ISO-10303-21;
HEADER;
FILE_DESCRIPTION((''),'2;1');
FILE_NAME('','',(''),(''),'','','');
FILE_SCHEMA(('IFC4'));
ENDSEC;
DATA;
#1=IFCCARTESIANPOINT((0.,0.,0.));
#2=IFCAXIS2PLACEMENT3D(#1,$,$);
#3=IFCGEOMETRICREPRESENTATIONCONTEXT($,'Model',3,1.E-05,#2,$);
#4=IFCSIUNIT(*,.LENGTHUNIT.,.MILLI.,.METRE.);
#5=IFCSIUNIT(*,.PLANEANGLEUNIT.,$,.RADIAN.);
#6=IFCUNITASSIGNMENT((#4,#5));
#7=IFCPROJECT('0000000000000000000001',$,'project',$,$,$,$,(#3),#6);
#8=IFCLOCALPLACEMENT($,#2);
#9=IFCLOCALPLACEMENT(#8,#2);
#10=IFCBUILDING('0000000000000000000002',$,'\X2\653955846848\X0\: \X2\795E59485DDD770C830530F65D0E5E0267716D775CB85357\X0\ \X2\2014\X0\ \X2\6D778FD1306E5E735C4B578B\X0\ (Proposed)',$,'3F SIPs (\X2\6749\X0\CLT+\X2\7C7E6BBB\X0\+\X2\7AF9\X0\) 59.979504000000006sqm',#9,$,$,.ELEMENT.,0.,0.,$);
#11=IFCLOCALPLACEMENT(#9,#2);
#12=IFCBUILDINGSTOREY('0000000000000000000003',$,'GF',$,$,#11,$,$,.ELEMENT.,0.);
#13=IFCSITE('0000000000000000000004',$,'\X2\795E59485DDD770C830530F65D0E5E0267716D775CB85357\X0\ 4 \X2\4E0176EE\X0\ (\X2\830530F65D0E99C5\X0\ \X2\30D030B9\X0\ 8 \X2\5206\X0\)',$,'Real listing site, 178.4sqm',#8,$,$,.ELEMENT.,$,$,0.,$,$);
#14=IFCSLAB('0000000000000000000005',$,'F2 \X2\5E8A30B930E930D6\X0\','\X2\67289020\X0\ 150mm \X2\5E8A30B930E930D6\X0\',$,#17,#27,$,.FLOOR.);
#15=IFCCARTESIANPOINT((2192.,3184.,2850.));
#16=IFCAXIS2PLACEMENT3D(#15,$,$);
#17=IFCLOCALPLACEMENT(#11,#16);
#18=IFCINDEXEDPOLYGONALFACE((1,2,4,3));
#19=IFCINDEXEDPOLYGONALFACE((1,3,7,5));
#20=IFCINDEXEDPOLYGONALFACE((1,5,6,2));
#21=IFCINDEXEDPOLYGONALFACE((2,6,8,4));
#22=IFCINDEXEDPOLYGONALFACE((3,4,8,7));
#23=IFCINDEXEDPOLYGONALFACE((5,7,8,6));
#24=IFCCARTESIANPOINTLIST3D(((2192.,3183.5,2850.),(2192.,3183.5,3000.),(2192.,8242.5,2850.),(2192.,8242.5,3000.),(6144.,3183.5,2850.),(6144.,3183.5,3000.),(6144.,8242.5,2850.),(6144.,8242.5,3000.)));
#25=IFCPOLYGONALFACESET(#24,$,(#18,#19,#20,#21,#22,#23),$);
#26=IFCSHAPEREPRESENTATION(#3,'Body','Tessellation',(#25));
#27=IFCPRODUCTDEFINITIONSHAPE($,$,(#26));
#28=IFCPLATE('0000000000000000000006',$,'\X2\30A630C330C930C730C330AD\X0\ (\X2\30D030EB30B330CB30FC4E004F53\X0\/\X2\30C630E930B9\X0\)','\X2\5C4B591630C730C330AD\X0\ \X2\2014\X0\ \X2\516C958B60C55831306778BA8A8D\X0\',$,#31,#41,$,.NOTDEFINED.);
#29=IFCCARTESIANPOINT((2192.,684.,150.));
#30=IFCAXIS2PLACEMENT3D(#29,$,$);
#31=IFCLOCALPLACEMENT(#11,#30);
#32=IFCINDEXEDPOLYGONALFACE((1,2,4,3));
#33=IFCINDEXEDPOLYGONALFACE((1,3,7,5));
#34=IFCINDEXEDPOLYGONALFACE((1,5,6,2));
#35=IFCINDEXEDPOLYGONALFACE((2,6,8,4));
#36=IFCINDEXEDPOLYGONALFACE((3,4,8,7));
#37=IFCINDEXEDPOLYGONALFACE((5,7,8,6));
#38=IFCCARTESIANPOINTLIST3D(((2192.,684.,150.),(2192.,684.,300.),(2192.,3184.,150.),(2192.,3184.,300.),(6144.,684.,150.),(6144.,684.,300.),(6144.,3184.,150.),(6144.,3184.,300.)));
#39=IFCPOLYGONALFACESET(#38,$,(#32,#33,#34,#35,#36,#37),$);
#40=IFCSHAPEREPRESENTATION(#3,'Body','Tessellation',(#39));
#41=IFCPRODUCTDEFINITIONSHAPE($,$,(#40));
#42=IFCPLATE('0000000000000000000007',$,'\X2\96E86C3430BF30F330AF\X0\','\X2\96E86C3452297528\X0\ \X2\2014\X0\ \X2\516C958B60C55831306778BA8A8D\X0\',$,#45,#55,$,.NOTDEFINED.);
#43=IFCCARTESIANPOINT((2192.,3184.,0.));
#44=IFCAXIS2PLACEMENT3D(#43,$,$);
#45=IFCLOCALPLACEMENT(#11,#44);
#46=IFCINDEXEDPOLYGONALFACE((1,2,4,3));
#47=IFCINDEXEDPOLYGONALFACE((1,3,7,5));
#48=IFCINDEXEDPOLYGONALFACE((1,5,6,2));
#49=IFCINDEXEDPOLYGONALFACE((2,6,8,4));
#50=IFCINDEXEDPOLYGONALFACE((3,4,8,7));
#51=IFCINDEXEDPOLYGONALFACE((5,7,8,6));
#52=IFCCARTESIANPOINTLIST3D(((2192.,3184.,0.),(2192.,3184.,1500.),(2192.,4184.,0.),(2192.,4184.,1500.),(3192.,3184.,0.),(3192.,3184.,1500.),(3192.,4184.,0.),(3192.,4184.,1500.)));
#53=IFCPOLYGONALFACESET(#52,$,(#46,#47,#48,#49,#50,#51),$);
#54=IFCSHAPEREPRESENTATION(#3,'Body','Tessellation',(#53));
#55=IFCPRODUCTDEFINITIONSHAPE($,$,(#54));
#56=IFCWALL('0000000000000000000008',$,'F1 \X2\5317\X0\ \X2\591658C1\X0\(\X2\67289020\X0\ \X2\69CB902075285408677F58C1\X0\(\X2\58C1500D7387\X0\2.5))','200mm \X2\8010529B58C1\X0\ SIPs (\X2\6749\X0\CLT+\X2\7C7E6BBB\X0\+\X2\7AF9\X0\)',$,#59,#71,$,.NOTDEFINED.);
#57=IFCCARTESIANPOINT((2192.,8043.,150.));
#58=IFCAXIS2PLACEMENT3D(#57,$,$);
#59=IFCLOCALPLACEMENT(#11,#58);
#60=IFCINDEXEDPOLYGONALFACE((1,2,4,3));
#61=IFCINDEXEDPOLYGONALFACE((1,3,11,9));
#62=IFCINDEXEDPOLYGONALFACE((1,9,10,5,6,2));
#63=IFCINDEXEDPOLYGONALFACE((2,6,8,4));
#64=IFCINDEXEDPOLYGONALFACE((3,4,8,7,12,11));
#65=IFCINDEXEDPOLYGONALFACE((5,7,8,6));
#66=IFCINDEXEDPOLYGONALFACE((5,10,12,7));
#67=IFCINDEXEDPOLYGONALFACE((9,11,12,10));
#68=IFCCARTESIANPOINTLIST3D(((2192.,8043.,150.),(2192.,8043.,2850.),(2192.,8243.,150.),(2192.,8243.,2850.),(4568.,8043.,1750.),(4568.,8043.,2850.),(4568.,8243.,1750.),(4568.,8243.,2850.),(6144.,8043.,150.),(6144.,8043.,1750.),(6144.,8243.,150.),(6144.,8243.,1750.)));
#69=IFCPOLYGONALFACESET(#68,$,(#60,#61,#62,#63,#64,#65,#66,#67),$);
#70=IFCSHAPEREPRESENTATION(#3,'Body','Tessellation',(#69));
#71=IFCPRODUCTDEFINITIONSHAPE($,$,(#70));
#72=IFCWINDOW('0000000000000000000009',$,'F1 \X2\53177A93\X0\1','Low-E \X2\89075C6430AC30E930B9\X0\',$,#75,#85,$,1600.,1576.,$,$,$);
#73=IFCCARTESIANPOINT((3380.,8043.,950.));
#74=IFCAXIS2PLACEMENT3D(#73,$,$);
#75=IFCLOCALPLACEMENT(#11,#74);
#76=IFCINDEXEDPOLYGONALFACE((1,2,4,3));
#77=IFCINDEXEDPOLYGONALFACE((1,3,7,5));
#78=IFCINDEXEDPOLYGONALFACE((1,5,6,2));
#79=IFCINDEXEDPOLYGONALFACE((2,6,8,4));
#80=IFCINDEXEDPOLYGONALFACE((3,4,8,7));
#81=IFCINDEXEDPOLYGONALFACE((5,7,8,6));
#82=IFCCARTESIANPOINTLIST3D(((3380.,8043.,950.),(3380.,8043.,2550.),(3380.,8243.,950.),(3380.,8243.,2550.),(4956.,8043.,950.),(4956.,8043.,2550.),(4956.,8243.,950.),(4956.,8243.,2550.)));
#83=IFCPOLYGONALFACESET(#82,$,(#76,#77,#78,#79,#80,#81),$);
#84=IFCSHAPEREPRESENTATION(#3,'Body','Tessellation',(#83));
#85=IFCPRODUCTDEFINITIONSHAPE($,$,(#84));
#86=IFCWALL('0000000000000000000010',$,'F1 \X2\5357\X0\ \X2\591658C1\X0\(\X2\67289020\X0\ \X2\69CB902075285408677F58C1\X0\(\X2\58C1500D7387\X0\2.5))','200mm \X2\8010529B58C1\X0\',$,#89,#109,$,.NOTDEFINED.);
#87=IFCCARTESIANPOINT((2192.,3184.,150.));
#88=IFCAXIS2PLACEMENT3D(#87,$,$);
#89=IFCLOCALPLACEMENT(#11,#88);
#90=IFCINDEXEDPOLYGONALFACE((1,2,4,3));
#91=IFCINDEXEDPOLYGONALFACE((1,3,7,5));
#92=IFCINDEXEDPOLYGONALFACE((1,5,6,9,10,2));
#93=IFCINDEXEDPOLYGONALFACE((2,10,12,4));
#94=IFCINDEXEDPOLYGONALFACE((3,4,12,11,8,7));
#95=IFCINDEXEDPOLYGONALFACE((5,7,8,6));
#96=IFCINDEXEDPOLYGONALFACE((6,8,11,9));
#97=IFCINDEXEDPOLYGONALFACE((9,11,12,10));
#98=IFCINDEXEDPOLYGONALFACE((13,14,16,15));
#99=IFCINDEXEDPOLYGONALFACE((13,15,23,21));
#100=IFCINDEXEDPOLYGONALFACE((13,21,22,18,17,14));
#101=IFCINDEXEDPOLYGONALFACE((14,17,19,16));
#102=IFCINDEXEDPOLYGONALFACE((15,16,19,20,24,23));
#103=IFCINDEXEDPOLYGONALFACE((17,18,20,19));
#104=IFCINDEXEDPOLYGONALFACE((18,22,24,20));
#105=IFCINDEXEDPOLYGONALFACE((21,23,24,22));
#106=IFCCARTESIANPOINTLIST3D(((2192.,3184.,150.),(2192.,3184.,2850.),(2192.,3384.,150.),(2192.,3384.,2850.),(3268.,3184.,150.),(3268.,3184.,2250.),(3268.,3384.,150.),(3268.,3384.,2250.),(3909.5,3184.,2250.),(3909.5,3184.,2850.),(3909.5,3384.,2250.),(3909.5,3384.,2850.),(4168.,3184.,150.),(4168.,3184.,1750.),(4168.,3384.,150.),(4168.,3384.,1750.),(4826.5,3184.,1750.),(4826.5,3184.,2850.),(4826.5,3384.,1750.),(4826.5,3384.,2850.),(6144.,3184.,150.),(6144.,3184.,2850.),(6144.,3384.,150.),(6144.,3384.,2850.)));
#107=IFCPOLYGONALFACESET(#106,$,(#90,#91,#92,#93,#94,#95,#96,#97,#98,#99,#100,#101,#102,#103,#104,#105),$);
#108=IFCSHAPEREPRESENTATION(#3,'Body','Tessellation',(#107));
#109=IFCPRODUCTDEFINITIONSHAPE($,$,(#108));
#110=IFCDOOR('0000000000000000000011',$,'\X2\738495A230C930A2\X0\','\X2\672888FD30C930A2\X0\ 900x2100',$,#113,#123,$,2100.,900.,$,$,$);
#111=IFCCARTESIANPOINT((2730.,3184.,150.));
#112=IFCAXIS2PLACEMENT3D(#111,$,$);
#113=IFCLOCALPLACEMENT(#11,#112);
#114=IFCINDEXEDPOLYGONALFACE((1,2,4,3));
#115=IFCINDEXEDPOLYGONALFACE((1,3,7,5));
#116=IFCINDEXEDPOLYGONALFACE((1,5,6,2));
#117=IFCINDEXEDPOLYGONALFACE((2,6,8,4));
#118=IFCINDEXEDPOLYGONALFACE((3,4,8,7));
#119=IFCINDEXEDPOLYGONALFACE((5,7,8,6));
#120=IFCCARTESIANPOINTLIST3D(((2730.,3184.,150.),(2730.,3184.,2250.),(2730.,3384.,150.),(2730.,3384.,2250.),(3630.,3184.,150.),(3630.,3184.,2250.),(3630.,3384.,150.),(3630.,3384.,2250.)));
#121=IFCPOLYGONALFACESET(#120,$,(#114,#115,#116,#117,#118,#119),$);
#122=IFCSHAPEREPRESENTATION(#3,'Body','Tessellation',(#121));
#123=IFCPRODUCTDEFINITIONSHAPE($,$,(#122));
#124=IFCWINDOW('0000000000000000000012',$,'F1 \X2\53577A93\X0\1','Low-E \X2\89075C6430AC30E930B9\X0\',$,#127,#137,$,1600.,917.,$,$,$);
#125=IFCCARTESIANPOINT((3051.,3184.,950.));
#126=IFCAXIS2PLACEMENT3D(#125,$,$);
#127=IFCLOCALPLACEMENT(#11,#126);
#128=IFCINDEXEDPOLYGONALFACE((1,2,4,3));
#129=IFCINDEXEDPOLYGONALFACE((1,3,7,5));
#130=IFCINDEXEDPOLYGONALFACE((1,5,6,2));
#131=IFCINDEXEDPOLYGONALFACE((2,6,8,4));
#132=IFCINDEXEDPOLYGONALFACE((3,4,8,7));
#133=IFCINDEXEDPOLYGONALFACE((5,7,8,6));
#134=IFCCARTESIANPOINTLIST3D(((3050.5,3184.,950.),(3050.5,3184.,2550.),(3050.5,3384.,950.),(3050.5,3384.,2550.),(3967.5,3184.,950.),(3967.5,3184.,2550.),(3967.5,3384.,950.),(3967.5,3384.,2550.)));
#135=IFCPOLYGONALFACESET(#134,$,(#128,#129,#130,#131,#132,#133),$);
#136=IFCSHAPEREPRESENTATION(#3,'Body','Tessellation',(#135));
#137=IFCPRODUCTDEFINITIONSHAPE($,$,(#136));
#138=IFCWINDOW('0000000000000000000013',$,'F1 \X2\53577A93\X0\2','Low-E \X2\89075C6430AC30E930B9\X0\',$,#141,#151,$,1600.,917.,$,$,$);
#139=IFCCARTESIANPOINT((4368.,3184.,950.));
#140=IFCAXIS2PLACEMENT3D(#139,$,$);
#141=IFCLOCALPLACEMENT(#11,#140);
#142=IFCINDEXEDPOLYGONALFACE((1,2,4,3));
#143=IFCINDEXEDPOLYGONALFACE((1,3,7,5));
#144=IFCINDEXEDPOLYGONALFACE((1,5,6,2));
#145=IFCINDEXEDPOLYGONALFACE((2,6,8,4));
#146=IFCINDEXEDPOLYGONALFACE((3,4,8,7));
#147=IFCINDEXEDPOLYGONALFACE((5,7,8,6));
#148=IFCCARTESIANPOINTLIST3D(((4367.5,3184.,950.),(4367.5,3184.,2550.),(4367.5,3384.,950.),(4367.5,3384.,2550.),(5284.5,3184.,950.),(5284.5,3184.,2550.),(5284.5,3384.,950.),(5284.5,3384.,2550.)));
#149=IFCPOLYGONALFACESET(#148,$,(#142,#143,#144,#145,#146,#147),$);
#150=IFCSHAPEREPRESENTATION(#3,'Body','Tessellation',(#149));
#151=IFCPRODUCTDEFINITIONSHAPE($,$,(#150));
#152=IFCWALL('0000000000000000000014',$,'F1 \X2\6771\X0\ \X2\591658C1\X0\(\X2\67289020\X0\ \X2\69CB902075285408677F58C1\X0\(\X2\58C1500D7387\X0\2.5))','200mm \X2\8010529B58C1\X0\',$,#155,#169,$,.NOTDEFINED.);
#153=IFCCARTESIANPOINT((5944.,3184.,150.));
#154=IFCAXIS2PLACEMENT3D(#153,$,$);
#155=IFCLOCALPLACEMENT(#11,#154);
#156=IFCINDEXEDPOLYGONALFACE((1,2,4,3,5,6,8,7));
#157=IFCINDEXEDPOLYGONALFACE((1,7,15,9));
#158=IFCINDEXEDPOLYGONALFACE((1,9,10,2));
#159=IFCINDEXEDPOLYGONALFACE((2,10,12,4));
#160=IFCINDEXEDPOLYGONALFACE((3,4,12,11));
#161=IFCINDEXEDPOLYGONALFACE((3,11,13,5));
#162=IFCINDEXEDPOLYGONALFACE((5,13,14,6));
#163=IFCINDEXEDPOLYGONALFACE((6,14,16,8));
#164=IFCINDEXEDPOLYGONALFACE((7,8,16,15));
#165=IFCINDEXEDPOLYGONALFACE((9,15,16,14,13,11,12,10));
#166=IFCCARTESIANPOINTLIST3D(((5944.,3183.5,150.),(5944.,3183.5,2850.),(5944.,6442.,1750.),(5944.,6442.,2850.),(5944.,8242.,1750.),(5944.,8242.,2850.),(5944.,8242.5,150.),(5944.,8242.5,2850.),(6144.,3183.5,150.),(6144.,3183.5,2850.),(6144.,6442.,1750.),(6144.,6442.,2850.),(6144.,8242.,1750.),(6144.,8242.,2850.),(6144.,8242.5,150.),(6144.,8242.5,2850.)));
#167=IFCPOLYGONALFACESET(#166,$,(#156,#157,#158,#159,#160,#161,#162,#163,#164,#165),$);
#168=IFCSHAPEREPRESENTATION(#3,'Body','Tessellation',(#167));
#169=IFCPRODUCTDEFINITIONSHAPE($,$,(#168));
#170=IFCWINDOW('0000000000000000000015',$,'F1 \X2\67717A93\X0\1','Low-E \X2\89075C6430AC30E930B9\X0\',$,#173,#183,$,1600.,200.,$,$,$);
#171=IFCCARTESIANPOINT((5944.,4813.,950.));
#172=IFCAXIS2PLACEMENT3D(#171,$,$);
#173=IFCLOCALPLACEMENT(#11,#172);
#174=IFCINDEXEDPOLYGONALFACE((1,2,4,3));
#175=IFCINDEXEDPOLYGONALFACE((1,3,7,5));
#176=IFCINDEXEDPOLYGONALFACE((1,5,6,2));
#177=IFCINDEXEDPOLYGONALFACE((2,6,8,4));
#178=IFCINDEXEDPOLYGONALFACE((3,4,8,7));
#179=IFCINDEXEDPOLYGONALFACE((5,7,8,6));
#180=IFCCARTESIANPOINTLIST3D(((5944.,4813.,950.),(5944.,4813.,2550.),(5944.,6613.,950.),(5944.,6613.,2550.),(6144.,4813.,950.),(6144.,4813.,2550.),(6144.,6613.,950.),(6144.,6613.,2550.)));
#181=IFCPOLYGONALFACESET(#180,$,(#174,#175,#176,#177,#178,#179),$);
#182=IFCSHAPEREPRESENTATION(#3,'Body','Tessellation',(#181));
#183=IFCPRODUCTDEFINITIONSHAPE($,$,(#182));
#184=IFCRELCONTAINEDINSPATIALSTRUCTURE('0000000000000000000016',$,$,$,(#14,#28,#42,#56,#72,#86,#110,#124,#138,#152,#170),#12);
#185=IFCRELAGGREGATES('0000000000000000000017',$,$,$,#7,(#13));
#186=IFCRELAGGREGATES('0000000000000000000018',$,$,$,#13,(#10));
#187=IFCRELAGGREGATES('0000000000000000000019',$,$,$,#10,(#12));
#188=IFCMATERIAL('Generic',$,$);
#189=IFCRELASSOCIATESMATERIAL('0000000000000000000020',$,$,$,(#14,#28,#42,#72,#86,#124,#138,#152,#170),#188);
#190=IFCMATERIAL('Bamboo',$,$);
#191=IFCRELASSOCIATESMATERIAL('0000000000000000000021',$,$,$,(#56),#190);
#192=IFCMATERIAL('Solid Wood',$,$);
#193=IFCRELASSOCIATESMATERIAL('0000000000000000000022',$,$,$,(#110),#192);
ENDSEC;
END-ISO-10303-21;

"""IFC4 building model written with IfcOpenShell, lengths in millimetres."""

from ifc_helpers import new_model, si_unit, frame, frame_2d, origin, place, context, project, spatial, rectangle, extrude, material, element, fill, save


model = new_model("IFC4")

# Units and contexts
model_context = context("Model", 3, precision=1e-05, world=origin())
ifc_project = project(units=[si_unit("LENGTHUNIT", "METRE", prefix="MILLI"), si_unit("PLANEANGLEUNIT", "RADIAN")], contexts=[model_context])

# Site, building, storey
site_placement = place(None, origin())
site = spatial("IfcSite", under=ifc_project, at=site_placement, Name="神奈川県茅ヶ崎市東海岸南 4 丁目 (茅ヶ崎駅 バス 8 分)", ObjectType="Real listing site, 178.4sqm", CompositionType="ELEMENT", RefElevation=0.0)
building_placement = place(site_placement, origin())
building = spatial("IfcBuilding", under=site, at=building_placement, Name="改善案: 神奈川県茅ヶ崎市東海岸南 — 海近の平屋型 (Proposed)", ObjectType="3F SIPs (杉CLT+籾殻+竹) 59.979504000000006sqm", CompositionType="ELEMENT", ElevationOfRefHeight=0.0, ElevationOfTerrain=0.0)
storey_placement = place(building_placement, origin())
storey = spatial("IfcBuildingStorey", under=building, at=storey_placement, Name="GF", CompositionType="ELEMENT", Elevation=0.0)

# Slab
ifc_material_1 = material(Name="Generic")
slab_1_placement = place(storey_placement, frame((2192.0, 3184.0, 2850.0)))
element("IfcSlab", 1, at=slab_1_placement, inside=storey, material=ifc_material_1, Name="F2 床スラブ", Description="木造 150mm 床スラブ", PredefinedType="FLOOR", context=model_context, shape_type="SweptSolid", body=[
    extrude(rectangle(XDim=3952.0, YDim=5059.0, at=frame_2d((1976.0, 2529.0))), frame((2192.0, 3184.0, 2850.0)), (0.0, 0.0, 1.0), 150.0),
])

# Plates
plate_1_placement = place(storey_placement, frame((2192.0, 684.0, 150.0)))
element("IfcPlate", 2, at=plate_1_placement, inside=storey, material=ifc_material_1, Name="ウッドデッキ (バルコニー一体/テラス)", Description="屋外デッキ — 公開情報で確認", PredefinedType="NOTDEFINED", context=model_context, shape_type="SweptSolid", body=[
    extrude(rectangle(XDim=3952.0, YDim=2500.0, at=frame_2d((1976.0, 1250.0))), frame((2192.0, 684.0, 150.0)), (0.0, 0.0, 1.0), 150.0),
])
plate_2_placement = place(storey_placement, frame((2192.0, 3184.0, 0.0)))
element("IfcPlate", 3, at=plate_2_placement, inside=storey, material=ifc_material_1, Name="雨水タンク", Description="雨水利用 — 公開情報で確認", PredefinedType="NOTDEFINED", context=model_context, shape_type="SweptSolid", body=[
    extrude(rectangle(XDim=1000.0, YDim=1000.0, at=frame_2d((500.0, 500.0))), frame((2192.0, 3184.0, 0.0)), (0.0, 0.0, 1.0), 1500.0),
])

# Wall, opening, window
ifc_material_2 = material(Name="Bamboo")
wall_1_placement = place(storey_placement, frame((2192.0, 8043.0, 150.0)))
wall_1 = element("IfcWall", 4, at=wall_1_placement, inside=storey, material=ifc_material_2, Name="F1 北 外壁(木造 構造用合板壁(壁倍率2.5))", Description="200mm 耐力壁 SIPs (杉CLT+籾殻+竹)", PredefinedType="NOTDEFINED", context=model_context, shape_type="SweptSolid", body=[
    extrude(rectangle(XDim=3952.0, YDim=200.0, at=frame_2d((1976.0, 100.0))), frame((2192.0, 8043.0, 150.0)), (0.0, 0.0, 1.0), 2700.0),
])
opening_1_placement = place(storey_placement, frame((3380.0, 8043.0, 950.0)))
opening_1 = element("IfcOpeningElement", 5, at=opening_1_placement, cuts=wall_1, PredefinedType="NOTDEFINED", context=model_context, shape_type="SweptSolid", body=[
    extrude(rectangle(XDim=1576.0, YDim=200.0, at=frame_2d((788.0, 100.0))), frame((3380.0, 8043.0, 950.0)), (0.0, 0.0, 1.0), 1600.0),
])
window_1_placement = place(storey_placement, frame((3380.0, 8043.0, 950.0)))
window_1 = element("IfcWindow", 6, at=window_1_placement, inside=storey, material=ifc_material_1, Name="F1 北窓1", Description="Low-E 複層ガラス", OverallHeight=1600.0, OverallWidth=1576.0, context=model_context, shape_type="SweptSolid", body=[
    extrude(rectangle(XDim=1576.0, YDim=200.0, at=frame_2d((788.0, 100.0))), frame((3380.0, 8043.0, 950.0)), (0.0, 0.0, 1.0), 1600.0),
])
fill(opening_1, window_1)

# Wall, openings, door, windows
wall_2_placement = place(storey_placement, frame((2192.0, 3184.0, 150.0)))
wall_2 = element("IfcWall", 7, at=wall_2_placement, inside=storey, material=ifc_material_1, Name="F1 南 外壁(木造 構造用合板壁(壁倍率2.5))", Description="200mm 耐力壁", PredefinedType="NOTDEFINED", context=model_context, shape_type="SweptSolid", body=[
    extrude(rectangle(XDim=3952.0, YDim=200.0, at=frame_2d((1976.0, 100.0))), frame((2192.0, 3184.0, 150.0)), (0.0, 0.0, 1.0), 2700.0),
])
opening_2_placement = place(storey_placement, frame((2730.0, 3184.0, 150.0)))
opening_2 = element("IfcOpeningElement", 8, at=opening_2_placement, cuts=wall_2, PredefinedType="NOTDEFINED", context=model_context, shape_type="SweptSolid", body=[
    extrude(rectangle(XDim=900.0, YDim=200.0, at=frame_2d((450.0, 100.0))), frame((2730.0, 3184.0, 150.0)), (0.0, 0.0, 1.0), 2100.0),
])
opening_3_placement = place(storey_placement, frame((3051.0, 3184.0, 950.0)))
opening_3 = element("IfcOpeningElement", 9, at=opening_3_placement, cuts=wall_2, PredefinedType="NOTDEFINED", context=model_context, shape_type="SweptSolid", body=[
    extrude(rectangle(XDim=917.0, YDim=200.0, at=frame_2d((458.0, 100.0))), frame((3051.0, 3184.0, 950.0)), (0.0, 0.0, 1.0), 1600.0),
])
opening_4_placement = place(storey_placement, frame((4368.0, 3184.0, 950.0)))
opening_4 = element("IfcOpeningElement", 10, at=opening_4_placement, cuts=wall_2, PredefinedType="NOTDEFINED", context=model_context, shape_type="SweptSolid", body=[
    extrude(rectangle(XDim=917.0, YDim=200.0, at=frame_2d((458.0, 100.0))), frame((4368.0, 3184.0, 950.0)), (0.0, 0.0, 1.0), 1600.0),
])
ifc_material_3 = material(Name="Solid Wood")
door_placement = place(storey_placement, frame((2730.0, 3184.0, 150.0)))
door = element("IfcDoor", 11, at=door_placement, inside=storey, material=ifc_material_3, Name="玄関ドア", Description="木製ドア 900x2100", OverallHeight=2100.0, OverallWidth=900.0, context=model_context, shape_type="SweptSolid", body=[
    extrude(rectangle(XDim=900.0, YDim=200.0, at=frame_2d((450.0, 100.0))), frame((2730.0, 3184.0, 150.0)), (0.0, 0.0, 1.0), 2100.0),
])
fill(opening_2, door)
window_2_placement = place(storey_placement, frame((3051.0, 3184.0, 950.0)))
window_2 = element("IfcWindow", 12, at=window_2_placement, inside=storey, material=ifc_material_1, Name="F1 南窓1", Description="Low-E 複層ガラス", OverallHeight=1600.0, OverallWidth=917.0, context=model_context, shape_type="SweptSolid", body=[
    extrude(rectangle(XDim=917.0, YDim=200.0, at=frame_2d((458.0, 100.0))), frame((3051.0, 3184.0, 950.0)), (0.0, 0.0, 1.0), 1600.0),
])
fill(opening_3, window_2)
window_3_placement = place(storey_placement, frame((4368.0, 3184.0, 950.0)))
window_3 = element("IfcWindow", 13, at=window_3_placement, inside=storey, material=ifc_material_1, Name="F1 南窓2", Description="Low-E 複層ガラス", OverallHeight=1600.0, OverallWidth=917.0, context=model_context, shape_type="SweptSolid", body=[
    extrude(rectangle(XDim=917.0, YDim=200.0, at=frame_2d((458.0, 100.0))), frame((4368.0, 3184.0, 950.0)), (0.0, 0.0, 1.0), 1600.0),
])
fill(opening_4, window_3)

# Wall, opening, window
wall_3_placement = place(storey_placement, frame((5944.0, 3184.0, 150.0)))
wall_3 = element("IfcWall", 14, at=wall_3_placement, inside=storey, material=ifc_material_1, Name="F1 東 外壁(木造 構造用合板壁(壁倍率2.5))", Description="200mm 耐力壁", PredefinedType="NOTDEFINED", context=model_context, shape_type="SweptSolid", body=[
    extrude(rectangle(XDim=200.0, YDim=5059.0, at=frame_2d((100.0, 2529.0))), frame((5944.0, 3184.0, 150.0)), (0.0, 0.0, 1.0), 2700.0),
])
opening_5_placement = place(storey_placement, frame((5944.0, 4813.0, 950.0)))
opening_5 = element("IfcOpeningElement", 15, at=opening_5_placement, cuts=wall_3, PredefinedType="NOTDEFINED", context=model_context, shape_type="SweptSolid", body=[
    extrude(rectangle(XDim=200.0, YDim=1800.0, at=frame_2d((100.0, 900.0))), frame((5944.0, 4813.0, 950.0)), (0.0, 0.0, 1.0), 1600.0),
])
window_4_placement = place(storey_placement, frame((5944.0, 4813.0, 950.0)))
window_4 = element("IfcWindow", 16, at=window_4_placement, inside=storey, material=ifc_material_1, Name="F1 東窓1", Description="Low-E 複層ガラス", OverallHeight=1600.0, OverallWidth=200.0, context=model_context, shape_type="SweptSolid", body=[
    extrude(rectangle(XDim=200.0, YDim=1800.0, at=frame_2d((100.0, 900.0))), frame((5944.0, 4813.0, 950.0)), (0.0, 0.0, 1.0), 1600.0),
])
fill(opening_5, window_4)

save(model, "model.ifc")
